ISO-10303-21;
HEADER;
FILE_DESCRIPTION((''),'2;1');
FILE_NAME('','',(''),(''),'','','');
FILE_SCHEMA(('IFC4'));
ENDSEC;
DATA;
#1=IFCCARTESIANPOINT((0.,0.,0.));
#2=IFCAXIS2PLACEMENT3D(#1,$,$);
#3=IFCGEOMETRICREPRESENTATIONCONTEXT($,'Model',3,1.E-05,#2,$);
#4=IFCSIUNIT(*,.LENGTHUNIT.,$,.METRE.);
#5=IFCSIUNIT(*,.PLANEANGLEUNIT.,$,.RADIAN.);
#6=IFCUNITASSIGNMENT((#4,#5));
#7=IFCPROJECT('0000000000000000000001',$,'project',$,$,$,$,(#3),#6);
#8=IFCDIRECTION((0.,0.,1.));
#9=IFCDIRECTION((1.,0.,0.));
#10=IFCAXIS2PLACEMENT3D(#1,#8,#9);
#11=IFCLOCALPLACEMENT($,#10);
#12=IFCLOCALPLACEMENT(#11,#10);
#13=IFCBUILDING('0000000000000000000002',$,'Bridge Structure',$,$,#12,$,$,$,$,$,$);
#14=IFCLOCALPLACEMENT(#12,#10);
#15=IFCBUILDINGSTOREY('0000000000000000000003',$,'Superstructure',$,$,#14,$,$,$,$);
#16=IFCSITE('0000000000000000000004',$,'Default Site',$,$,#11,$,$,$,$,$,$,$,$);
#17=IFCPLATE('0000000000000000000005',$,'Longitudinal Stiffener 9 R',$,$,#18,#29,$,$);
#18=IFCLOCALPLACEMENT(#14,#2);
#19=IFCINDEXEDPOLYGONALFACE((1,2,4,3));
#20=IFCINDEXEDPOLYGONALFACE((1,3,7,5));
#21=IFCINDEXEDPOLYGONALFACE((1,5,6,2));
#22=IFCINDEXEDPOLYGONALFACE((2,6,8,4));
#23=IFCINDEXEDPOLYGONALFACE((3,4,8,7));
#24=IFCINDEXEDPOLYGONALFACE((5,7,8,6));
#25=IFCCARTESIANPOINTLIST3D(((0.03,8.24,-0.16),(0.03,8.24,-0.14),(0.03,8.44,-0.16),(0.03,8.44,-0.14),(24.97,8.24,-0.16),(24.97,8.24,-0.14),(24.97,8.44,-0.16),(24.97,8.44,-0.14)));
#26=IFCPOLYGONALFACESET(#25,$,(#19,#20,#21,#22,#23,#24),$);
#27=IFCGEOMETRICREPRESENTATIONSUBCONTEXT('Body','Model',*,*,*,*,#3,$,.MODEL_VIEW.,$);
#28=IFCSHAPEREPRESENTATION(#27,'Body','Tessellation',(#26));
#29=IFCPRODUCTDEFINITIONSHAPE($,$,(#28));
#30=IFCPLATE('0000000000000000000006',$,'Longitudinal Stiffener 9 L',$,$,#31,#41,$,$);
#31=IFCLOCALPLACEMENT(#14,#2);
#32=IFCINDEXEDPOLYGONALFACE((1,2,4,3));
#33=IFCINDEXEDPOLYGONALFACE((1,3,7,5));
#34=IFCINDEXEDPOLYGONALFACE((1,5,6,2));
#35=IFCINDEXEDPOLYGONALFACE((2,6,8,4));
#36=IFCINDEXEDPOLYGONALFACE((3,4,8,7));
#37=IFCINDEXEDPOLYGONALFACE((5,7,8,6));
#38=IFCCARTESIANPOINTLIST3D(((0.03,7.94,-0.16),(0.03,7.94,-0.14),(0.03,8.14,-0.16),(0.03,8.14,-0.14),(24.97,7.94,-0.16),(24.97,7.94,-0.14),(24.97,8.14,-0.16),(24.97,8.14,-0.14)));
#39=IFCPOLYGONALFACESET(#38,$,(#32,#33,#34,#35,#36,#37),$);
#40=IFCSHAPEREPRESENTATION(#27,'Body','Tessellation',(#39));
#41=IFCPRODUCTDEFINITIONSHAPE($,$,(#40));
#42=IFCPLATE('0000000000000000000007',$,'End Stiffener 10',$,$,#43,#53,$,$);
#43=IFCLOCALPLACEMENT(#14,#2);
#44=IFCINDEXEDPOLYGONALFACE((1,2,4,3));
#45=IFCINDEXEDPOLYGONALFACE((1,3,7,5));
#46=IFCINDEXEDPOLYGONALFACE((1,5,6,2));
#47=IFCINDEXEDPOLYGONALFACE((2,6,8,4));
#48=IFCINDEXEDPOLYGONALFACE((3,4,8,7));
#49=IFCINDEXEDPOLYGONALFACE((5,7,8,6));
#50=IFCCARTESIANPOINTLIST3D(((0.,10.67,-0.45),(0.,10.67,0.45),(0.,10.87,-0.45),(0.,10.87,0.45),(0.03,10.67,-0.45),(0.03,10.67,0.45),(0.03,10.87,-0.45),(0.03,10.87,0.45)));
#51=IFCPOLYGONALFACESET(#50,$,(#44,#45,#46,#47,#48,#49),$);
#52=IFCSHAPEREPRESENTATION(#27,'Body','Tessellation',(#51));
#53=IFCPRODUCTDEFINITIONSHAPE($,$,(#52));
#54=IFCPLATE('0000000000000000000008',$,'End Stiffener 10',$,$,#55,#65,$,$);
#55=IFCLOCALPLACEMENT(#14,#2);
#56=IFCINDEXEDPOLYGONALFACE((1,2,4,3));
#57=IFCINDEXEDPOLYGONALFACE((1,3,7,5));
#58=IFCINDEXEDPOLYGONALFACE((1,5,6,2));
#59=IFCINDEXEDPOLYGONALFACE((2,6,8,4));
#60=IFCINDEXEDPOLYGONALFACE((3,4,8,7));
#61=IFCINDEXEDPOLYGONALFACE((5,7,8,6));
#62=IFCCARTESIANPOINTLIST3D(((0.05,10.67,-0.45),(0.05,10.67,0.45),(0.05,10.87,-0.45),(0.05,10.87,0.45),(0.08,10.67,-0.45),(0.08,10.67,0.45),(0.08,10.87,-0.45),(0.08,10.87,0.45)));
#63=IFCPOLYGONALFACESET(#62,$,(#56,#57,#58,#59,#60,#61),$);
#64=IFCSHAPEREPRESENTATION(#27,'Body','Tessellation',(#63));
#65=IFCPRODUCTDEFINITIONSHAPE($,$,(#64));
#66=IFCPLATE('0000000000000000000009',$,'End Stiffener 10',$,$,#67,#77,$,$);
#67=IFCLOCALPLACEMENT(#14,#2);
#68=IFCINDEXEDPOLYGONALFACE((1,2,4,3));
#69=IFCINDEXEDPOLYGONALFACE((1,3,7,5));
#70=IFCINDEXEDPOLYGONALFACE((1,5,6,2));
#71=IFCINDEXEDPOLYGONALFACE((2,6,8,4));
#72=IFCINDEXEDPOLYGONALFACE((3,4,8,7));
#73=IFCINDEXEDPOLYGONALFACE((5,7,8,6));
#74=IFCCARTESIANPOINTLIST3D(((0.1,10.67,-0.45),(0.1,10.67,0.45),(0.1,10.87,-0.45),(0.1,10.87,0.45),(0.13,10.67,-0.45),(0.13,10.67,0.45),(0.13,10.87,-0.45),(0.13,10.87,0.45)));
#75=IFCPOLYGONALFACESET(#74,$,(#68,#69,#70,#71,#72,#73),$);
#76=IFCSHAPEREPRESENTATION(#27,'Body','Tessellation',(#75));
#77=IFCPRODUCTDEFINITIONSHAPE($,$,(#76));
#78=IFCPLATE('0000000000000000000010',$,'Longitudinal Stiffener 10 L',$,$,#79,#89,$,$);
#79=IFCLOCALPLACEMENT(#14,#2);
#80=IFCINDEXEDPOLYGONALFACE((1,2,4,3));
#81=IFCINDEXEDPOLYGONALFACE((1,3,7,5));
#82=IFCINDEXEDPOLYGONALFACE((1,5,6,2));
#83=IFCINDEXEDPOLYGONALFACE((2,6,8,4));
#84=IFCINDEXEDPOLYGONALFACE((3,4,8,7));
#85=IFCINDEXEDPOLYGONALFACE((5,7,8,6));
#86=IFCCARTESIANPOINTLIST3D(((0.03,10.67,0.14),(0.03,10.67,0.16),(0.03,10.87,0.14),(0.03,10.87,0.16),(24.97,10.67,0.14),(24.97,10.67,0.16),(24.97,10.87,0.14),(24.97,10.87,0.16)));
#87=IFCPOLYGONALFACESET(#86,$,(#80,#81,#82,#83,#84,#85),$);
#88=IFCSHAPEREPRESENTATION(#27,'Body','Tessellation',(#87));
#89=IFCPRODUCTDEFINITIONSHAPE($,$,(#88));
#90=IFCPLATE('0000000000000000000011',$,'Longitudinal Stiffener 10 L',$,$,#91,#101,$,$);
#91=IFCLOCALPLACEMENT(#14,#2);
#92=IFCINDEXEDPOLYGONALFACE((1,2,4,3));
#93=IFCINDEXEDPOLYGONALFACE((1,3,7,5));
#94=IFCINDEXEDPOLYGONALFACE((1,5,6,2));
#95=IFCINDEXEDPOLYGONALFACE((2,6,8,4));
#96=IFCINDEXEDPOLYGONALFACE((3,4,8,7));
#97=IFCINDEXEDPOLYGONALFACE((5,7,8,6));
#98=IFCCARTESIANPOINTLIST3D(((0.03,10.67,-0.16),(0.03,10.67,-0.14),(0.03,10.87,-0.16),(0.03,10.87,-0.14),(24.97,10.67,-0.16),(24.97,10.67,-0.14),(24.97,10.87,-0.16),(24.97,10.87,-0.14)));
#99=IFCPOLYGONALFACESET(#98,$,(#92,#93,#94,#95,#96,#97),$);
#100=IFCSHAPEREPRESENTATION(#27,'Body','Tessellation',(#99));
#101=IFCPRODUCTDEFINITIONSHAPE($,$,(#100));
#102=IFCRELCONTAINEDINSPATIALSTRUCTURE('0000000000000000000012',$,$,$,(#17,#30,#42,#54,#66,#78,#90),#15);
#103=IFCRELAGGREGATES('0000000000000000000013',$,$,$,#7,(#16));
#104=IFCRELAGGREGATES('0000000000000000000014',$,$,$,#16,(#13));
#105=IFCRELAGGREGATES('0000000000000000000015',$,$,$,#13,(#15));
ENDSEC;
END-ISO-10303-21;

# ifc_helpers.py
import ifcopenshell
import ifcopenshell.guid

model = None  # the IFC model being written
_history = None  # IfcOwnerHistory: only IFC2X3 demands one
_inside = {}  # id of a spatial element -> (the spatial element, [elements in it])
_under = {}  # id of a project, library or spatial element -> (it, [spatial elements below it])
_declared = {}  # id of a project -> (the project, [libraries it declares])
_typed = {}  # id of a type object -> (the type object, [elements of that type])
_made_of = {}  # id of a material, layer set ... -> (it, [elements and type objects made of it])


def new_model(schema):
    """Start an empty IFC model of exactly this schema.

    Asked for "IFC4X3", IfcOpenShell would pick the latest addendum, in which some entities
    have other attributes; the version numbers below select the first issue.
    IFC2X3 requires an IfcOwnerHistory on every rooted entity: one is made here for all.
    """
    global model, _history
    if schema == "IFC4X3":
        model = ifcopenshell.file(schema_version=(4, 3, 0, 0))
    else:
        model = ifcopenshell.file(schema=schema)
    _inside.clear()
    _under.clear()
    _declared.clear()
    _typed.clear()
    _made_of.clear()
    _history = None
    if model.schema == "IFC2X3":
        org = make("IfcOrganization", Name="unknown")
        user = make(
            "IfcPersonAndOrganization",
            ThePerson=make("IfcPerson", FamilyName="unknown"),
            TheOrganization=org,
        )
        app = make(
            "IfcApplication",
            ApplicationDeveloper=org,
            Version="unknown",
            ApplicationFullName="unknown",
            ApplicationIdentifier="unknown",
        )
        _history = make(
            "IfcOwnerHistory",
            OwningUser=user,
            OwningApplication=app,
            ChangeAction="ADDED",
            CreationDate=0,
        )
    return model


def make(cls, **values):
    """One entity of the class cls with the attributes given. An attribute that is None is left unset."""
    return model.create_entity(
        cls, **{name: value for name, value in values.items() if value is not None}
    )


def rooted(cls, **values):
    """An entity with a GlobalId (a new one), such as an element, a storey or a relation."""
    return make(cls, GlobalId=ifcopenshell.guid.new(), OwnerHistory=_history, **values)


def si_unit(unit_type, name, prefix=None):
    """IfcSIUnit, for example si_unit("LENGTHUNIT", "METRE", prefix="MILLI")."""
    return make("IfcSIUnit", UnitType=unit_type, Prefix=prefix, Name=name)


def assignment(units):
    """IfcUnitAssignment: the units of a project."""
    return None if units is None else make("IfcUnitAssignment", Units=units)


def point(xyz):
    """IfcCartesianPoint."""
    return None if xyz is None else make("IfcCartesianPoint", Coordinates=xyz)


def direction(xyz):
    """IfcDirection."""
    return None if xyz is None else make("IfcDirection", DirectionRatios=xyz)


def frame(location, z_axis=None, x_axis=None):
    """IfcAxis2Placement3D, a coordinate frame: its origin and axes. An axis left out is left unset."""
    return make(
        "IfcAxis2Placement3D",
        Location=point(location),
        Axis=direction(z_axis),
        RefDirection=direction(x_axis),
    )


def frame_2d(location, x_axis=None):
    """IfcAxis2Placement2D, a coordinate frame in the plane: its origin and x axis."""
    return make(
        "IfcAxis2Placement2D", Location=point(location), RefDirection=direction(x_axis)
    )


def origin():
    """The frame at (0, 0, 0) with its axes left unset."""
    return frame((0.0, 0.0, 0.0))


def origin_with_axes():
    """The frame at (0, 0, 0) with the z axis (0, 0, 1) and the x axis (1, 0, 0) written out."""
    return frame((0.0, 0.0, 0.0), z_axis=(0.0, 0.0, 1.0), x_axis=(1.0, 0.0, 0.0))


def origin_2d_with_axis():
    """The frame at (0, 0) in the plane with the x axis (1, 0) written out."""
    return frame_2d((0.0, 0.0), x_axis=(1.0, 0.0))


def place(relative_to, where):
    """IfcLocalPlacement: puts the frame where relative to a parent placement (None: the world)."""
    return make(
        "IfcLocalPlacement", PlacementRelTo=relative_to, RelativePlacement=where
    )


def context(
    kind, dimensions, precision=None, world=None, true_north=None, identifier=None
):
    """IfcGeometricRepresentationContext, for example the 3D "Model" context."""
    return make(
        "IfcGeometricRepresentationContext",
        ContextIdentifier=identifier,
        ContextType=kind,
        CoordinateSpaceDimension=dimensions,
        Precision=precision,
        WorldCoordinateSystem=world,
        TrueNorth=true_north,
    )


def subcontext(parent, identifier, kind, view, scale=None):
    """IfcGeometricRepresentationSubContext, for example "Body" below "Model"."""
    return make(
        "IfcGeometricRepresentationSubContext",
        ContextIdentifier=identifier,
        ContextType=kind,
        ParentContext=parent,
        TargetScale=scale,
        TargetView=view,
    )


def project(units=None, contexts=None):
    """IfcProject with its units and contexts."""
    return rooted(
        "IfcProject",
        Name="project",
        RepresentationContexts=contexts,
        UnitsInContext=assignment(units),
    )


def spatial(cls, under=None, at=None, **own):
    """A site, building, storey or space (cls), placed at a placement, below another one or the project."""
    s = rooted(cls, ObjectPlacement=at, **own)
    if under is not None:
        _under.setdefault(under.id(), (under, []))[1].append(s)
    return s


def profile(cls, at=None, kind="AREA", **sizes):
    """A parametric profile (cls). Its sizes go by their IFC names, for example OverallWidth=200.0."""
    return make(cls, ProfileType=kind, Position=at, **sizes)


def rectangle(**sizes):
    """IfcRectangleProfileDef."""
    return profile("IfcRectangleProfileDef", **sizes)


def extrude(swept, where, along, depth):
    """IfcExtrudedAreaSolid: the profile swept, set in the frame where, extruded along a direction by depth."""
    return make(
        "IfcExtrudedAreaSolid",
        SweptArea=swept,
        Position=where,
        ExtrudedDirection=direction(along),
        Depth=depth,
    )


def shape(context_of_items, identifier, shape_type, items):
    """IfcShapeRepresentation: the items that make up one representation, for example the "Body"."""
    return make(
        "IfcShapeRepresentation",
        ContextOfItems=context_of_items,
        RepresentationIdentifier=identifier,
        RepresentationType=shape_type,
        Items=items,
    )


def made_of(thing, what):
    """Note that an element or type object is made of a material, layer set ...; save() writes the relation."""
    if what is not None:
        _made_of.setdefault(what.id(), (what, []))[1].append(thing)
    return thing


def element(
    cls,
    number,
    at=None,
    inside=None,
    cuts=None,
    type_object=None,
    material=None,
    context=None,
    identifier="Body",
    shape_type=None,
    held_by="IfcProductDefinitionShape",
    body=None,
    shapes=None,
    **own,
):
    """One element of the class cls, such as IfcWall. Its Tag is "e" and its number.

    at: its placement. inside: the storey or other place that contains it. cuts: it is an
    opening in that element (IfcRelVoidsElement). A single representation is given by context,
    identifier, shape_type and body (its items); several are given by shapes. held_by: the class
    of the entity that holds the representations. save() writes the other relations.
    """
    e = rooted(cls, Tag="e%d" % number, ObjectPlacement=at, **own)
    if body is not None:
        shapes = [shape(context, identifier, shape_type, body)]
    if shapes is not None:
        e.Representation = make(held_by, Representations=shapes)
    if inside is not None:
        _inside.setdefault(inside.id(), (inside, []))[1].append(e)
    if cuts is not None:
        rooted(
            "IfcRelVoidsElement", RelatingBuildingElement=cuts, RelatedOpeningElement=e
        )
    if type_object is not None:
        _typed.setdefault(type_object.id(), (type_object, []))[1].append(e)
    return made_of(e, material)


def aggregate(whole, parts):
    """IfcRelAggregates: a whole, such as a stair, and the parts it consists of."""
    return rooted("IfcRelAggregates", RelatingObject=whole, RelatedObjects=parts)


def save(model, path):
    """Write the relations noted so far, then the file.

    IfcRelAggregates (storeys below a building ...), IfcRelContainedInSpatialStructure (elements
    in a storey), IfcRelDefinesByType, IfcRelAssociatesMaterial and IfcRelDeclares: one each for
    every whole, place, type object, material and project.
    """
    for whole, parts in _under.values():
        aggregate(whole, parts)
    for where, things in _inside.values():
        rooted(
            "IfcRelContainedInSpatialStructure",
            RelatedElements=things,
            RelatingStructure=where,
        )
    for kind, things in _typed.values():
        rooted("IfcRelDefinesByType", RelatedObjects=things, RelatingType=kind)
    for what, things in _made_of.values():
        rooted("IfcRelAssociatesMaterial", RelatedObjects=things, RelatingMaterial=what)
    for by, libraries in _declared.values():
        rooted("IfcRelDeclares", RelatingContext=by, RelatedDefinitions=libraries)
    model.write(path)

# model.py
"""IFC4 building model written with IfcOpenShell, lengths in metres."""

from ifc_helpers import new_model, si_unit, frame, origin, origin_with_axes, origin_2d_with_axis, place, context, subcontext, project, spatial, rectangle, extrude, element, save


model = new_model("IFC4")

# Units and contexts
model_context = context("Model", 3, precision=1e-05, world=origin())
body_context = subcontext(model_context, "Body", "Model", "MODEL_VIEW")
ifc_project = project(units=[si_unit("LENGTHUNIT", "METRE"), si_unit("PLANEANGLEUNIT", "RADIAN")], contexts=[model_context])

# Site, building, storey
site_placement = place(None, origin_with_axes())
site = spatial("IfcSite", under=ifc_project, at=site_placement, Name="Default Site")
building_placement = place(site_placement, origin_with_axes())
building = spatial("IfcBuilding", under=site, at=building_placement, Name="Bridge Structure")
storey_placement = place(building_placement, origin_with_axes())
storey = spatial("IfcBuildingStorey", under=building, at=storey_placement, Name="Superstructure")

# Plates
for number, where, z_axis, x_axis, name in (
    (1, (0.03, 8.34, -0.15), (1.0, 0.0, 0.0), (0.0, 1.0, 0.0), "Longitudinal Stiffener 9 R"),
    (2, (0.03, 8.04, -0.15), (1.0, 0.0, 0.0), (0.0, 1.0, 0.0), "Longitudinal Stiffener 9 L"),
):
    element("IfcPlate", number, at=place(storey_placement, frame(where, z_axis=z_axis, x_axis=x_axis)), inside=storey, Name=name, context=body_context, shape_type="SweptSolid", body=[
        extrude(rectangle(XDim=0.2, YDim=0.02, at=origin_2d_with_axis()), origin_with_axes(), (0.0, 0.0, 1.0), 24.94),
    ])
for number, where, z_axis, x_axis, name in (
    (3, (0.015, 10.77, -0.45), (0.0, 0.0, 1.0), (1.0, 0.0, 0.0), "End Stiffener 10"),
    (4, (0.065, 10.77, -0.45), (0.0, 0.0, 1.0), (1.0, 0.0, 0.0), "End Stiffener 10"),
    (5, (0.115, 10.77, -0.45), (0.0, 0.0, 1.0), (1.0, 0.0, 0.0), "End Stiffener 10"),
):
    element("IfcPlate", number, at=place(storey_placement, frame(where, z_axis=z_axis, x_axis=x_axis)), inside=storey, Name=name, context=body_context, shape_type="SweptSolid", body=[
        extrude(rectangle(XDim=0.03, YDim=0.2, at=origin_2d_with_axis()), origin_with_axes(), (0.0, 0.0, 1.0), 0.9),
    ])
for number, where, z_axis, x_axis, name in (
    (6, (0.03, 10.77, 0.15), (1.0, 0.0, 0.0), (0.0, 1.0, 0.0), "Longitudinal Stiffener 10 L"),
    (7, (0.03, 10.77, -0.15), (1.0, 0.0, 0.0), (0.0, 1.0, 0.0), "Longitudinal Stiffener 10 L"),
):
    element("IfcPlate", number, at=place(storey_placement, frame(where, z_axis=z_axis, x_axis=x_axis)), inside=storey, Name=name, context=body_context, shape_type="SweptSolid", body=[
        extrude(rectangle(XDim=0.2, YDim=0.02, at=origin_2d_with_axis()), origin_with_axes(), (0.0, 0.0, 1.0), 24.94),
    ])

save(model, "model.ifc")
